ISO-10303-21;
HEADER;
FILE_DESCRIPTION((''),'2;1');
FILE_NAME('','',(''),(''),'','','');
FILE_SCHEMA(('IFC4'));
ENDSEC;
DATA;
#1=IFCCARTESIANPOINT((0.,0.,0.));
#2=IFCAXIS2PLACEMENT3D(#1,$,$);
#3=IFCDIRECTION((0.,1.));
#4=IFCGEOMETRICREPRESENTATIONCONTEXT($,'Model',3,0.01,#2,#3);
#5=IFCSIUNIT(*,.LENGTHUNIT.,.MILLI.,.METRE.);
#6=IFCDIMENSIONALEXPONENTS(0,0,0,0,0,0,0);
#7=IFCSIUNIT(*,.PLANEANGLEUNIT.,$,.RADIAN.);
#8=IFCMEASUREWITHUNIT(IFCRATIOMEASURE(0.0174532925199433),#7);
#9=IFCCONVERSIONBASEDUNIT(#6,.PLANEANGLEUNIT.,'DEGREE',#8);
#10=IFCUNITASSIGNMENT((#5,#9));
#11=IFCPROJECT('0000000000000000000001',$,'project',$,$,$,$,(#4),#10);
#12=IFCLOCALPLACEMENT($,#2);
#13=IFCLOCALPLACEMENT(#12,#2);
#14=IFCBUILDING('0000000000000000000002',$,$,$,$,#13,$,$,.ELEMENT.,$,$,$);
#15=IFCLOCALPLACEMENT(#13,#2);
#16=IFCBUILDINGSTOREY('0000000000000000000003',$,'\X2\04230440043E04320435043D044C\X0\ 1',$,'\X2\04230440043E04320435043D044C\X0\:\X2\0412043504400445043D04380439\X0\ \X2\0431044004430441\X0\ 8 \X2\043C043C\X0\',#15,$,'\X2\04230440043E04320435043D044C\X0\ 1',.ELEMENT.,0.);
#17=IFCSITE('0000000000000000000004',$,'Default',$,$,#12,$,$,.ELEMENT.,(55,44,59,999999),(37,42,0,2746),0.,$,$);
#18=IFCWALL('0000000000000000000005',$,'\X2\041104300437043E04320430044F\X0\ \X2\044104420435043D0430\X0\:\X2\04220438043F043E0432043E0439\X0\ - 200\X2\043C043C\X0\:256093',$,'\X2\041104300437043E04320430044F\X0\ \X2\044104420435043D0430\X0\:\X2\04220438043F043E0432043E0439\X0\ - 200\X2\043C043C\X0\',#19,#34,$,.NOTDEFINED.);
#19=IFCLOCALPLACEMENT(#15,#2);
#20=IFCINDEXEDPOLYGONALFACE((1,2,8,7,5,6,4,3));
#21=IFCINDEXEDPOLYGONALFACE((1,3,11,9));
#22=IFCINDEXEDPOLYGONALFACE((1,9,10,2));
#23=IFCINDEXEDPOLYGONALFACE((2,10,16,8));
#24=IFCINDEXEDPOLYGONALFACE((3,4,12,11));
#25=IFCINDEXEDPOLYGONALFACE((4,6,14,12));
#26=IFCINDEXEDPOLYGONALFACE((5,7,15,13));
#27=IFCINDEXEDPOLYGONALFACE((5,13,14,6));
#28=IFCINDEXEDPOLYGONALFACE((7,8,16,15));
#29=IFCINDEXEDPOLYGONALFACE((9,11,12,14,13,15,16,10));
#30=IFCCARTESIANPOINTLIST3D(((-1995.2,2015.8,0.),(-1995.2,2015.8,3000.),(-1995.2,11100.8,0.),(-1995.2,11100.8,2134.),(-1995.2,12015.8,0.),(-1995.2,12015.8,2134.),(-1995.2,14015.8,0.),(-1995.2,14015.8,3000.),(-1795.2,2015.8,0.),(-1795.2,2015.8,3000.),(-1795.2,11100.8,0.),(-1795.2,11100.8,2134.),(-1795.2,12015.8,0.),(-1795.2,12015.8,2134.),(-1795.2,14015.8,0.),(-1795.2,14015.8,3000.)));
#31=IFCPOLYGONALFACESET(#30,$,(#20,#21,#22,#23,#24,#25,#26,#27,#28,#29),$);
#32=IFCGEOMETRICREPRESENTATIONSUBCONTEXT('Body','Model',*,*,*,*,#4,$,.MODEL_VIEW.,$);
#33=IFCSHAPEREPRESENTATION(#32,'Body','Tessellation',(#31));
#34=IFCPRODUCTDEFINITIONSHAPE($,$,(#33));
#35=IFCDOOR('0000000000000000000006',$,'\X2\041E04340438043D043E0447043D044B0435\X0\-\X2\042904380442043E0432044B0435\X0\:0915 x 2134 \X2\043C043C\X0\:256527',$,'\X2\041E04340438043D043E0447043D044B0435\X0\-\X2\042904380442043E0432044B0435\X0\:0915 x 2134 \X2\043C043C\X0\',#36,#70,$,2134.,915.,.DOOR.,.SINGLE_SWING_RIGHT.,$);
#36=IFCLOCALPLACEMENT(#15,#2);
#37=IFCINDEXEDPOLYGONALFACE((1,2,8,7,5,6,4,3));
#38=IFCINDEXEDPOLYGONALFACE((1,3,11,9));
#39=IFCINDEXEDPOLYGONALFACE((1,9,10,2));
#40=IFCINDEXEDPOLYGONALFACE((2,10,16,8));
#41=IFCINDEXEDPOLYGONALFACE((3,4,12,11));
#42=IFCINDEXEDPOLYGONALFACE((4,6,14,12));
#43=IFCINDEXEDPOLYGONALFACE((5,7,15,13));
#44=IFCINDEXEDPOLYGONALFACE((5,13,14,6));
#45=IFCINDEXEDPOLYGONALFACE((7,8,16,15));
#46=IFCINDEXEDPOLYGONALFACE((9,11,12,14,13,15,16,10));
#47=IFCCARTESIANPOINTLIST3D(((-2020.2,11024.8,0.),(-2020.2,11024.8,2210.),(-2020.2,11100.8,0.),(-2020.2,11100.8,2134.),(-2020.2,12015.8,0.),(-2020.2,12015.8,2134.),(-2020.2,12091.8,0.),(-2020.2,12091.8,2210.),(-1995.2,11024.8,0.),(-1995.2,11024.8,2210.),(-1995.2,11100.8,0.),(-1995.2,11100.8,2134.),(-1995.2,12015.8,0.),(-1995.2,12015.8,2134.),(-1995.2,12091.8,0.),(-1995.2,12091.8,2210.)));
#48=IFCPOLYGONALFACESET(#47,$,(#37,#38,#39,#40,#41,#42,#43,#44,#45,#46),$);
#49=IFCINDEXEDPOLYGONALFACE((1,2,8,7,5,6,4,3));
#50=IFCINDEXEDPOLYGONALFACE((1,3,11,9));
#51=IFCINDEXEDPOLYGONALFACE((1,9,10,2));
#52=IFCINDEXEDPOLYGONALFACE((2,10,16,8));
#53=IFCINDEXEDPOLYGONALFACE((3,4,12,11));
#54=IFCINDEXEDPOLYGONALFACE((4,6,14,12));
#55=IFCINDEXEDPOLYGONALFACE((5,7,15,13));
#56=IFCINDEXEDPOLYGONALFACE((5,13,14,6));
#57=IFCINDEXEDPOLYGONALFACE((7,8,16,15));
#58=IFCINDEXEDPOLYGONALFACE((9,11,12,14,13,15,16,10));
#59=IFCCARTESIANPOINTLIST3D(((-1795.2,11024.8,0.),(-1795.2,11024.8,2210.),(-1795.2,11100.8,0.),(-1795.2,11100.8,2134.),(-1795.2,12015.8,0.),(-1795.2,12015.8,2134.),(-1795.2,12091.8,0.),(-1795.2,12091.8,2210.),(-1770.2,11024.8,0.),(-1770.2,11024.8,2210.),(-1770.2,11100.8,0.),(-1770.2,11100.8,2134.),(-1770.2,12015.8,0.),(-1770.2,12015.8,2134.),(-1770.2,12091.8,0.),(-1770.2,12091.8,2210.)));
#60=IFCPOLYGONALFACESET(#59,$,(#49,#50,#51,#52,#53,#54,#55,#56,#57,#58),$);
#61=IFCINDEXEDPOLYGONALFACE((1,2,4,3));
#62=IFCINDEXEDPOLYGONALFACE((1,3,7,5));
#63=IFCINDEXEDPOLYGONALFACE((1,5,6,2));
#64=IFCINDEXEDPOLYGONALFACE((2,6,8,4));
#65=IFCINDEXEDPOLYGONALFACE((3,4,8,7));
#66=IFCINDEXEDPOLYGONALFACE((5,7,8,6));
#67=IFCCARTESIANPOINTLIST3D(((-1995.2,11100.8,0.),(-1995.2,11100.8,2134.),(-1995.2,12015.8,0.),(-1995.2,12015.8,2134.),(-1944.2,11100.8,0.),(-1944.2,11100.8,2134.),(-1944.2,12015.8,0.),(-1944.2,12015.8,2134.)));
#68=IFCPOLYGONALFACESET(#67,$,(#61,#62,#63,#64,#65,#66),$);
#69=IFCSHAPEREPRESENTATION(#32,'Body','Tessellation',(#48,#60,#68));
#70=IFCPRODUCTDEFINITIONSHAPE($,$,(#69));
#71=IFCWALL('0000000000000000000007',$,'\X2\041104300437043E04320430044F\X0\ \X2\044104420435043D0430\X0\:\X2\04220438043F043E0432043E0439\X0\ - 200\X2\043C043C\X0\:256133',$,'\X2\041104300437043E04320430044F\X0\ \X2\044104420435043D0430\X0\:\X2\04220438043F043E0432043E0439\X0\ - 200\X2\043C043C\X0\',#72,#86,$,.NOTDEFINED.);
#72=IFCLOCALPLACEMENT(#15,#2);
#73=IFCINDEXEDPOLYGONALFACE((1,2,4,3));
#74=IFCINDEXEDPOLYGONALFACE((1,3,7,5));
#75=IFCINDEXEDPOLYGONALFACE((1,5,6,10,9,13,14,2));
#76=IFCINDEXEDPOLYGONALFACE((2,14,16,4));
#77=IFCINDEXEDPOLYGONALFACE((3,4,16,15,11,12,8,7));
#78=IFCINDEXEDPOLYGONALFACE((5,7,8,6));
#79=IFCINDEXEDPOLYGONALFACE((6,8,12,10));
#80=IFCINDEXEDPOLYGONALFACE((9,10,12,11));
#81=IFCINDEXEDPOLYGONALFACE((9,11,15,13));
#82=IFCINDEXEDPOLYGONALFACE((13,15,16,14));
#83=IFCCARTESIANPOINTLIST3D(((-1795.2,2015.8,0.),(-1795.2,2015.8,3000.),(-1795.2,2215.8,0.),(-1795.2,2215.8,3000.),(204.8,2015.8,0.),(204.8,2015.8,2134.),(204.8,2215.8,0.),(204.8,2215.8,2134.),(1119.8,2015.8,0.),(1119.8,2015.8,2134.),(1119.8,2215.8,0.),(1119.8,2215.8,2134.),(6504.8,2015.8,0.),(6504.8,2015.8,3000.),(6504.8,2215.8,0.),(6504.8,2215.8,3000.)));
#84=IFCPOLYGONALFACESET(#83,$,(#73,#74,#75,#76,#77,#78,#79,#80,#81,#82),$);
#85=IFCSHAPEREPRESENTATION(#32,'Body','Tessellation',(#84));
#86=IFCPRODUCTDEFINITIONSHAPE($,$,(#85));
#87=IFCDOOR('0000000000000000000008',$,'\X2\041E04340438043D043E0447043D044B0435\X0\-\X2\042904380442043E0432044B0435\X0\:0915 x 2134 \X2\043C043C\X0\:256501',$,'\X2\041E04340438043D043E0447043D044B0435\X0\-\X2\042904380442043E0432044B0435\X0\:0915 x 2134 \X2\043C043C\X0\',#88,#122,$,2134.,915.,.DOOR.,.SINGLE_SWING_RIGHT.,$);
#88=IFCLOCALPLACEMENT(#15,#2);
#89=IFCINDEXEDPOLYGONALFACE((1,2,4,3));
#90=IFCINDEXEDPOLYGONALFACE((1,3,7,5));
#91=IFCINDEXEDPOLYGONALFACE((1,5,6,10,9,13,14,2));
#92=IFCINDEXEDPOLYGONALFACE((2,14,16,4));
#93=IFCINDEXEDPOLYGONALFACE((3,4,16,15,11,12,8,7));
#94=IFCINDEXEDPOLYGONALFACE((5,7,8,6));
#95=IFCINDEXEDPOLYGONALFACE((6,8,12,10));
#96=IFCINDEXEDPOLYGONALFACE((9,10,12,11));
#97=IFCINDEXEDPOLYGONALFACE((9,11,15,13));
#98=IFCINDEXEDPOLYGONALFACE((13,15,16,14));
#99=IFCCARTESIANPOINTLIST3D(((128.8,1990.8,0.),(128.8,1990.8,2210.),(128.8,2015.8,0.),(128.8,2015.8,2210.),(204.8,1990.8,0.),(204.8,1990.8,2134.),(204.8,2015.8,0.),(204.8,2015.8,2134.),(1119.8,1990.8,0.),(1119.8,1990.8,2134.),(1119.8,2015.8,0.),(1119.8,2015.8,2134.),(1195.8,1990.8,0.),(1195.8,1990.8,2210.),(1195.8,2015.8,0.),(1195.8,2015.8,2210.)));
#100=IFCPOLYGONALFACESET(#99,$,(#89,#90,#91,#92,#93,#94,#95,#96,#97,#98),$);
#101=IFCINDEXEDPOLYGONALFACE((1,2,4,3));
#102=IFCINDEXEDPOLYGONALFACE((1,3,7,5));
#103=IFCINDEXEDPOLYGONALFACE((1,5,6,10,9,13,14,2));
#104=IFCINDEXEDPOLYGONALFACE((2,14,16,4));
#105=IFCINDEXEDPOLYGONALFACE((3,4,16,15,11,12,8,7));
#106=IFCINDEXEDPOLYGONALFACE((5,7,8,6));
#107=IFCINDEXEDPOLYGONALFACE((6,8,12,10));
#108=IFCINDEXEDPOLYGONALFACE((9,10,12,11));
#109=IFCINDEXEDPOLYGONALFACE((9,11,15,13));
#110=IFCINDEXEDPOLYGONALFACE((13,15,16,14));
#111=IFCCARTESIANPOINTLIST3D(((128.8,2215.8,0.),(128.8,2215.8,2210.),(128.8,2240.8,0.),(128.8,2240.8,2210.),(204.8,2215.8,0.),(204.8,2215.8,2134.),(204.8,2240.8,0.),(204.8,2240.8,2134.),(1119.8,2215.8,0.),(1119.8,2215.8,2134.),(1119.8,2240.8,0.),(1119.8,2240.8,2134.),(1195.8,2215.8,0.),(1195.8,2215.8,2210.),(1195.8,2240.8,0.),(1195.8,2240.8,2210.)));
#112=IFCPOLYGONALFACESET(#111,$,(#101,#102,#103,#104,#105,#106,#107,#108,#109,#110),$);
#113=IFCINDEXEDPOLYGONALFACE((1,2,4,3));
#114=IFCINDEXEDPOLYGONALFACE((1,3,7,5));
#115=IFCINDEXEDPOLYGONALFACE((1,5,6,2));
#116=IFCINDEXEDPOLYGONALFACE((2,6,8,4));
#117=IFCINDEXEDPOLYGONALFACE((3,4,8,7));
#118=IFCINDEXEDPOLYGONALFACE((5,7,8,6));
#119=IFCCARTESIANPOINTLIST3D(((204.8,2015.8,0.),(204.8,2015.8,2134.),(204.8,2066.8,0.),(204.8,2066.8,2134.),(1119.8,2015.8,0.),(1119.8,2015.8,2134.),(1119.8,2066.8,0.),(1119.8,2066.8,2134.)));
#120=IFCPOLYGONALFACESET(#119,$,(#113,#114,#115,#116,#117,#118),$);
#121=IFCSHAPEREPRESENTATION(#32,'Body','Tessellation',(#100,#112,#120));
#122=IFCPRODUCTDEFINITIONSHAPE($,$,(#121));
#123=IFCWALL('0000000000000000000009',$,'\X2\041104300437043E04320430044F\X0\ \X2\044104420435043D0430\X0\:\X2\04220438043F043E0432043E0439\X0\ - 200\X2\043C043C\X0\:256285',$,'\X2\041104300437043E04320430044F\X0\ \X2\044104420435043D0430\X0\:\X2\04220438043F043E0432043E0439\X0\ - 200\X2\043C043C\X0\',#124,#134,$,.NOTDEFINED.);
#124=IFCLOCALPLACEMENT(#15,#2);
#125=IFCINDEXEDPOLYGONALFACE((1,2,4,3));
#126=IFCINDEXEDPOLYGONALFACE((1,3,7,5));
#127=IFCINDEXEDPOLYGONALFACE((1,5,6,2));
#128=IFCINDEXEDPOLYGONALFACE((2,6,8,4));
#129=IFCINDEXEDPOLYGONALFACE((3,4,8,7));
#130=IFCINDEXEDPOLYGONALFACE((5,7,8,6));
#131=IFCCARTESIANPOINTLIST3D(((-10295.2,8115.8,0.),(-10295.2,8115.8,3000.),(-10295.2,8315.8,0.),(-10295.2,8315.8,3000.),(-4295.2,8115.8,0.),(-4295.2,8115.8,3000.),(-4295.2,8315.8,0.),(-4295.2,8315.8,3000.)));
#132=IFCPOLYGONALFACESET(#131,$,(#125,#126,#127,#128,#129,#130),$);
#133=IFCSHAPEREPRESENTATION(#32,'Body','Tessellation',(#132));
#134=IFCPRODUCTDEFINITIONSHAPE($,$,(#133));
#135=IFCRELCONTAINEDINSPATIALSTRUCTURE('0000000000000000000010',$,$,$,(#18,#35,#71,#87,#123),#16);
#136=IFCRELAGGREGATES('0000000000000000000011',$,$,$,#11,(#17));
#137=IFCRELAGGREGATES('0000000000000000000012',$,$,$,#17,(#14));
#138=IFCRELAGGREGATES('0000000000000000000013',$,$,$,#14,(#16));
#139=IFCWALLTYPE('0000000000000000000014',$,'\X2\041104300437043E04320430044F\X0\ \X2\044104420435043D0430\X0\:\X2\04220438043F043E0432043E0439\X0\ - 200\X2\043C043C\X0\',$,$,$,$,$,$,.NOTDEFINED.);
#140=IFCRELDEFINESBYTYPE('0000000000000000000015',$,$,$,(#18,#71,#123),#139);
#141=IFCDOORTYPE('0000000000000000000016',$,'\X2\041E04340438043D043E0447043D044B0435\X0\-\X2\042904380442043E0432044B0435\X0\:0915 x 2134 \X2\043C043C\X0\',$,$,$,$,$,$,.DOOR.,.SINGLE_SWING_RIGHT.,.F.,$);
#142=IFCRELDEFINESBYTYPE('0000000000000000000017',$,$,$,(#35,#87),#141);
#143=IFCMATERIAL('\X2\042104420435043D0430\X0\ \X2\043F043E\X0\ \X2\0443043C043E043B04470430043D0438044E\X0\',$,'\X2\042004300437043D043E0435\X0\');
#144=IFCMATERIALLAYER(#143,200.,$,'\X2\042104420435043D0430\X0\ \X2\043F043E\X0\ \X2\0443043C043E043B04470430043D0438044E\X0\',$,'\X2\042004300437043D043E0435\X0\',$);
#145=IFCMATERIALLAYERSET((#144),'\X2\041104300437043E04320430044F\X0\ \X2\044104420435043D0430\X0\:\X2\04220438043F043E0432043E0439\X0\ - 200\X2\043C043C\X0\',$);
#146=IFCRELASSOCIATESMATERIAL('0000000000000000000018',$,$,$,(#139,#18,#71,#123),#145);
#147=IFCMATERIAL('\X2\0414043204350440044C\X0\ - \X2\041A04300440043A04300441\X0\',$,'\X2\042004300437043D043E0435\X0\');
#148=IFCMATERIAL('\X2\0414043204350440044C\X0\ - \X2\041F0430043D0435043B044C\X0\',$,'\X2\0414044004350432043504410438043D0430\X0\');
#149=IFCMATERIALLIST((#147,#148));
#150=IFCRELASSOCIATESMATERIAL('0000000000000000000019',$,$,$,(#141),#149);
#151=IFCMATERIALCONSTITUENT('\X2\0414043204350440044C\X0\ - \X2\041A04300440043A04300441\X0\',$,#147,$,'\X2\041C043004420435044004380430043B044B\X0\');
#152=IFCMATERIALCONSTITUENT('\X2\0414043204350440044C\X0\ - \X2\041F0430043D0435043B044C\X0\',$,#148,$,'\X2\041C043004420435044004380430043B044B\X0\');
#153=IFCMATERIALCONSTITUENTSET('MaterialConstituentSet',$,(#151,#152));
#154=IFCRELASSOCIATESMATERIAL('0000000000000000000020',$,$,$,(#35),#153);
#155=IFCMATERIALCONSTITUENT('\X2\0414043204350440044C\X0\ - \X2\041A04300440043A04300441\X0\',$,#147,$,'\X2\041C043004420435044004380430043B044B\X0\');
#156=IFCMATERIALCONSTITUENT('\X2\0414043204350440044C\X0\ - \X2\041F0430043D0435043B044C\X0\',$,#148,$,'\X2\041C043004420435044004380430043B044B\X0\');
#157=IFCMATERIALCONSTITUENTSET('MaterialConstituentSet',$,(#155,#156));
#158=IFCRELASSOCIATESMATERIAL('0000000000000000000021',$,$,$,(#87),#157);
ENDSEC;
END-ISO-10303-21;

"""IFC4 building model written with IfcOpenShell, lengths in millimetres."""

from ifc_helpers import new_model, entity, si_unit, converted_unit, direction, frame, frame_2d, origin, place, context, subcontext, project, spatial, polyline, rectangle, outline, extrude, source, transform, mapped, material, material_list, layer, layer_set, layer_usage, constituent, constituent_set, type_object, type_shapes, element, fill, save


model = new_model("IFC4")

# Units and contexts
model_context = context("Model", 3, precision=0.01, world=origin(), true_north=direction((0.0, 1.0)))
body_context = subcontext(model_context, "Body", "Model", "MODEL_VIEW")
ifc_project = project(units=[si_unit("LENGTHUNIT", "METRE", prefix="MILLI"), converted_unit("PLANEANGLEUNIT", "DEGREE", entity("IfcRatioMeasure", 0.0174532925199433), si_unit("PLANEANGLEUNIT", "RADIAN"), dimensions=[0, 0, 0, 0, 0, 0, 0])], contexts=[model_context])

# Site, building, storey
site_placement = place(None, origin())
site = spatial("IfcSite", under=ifc_project, at=site_placement, Name="Default", CompositionType="ELEMENT", RefLatitude=(55, 44, 59, 999999), RefLongitude=(37, 42, 0, 2746), RefElevation=0.0)
building_placement = place(site_placement, origin())
building = spatial("IfcBuilding", under=site, at=building_placement, CompositionType="ELEMENT")
storey_placement = place(building_placement, origin())
storey = spatial("IfcBuildingStorey", under=building, at=storey_placement, Name="Уровень 1", ObjectType="Уровень:Верхний брус 8 мм", LongName="Уровень 1", CompositionType="ELEMENT", Elevation=0.0)

# Shared definitions
ifc_material_1 = material(Name="Стена по умолчанию", Category="Разное")
ifc_layer_1 = layer(ifc_material_1, 200.0, Name="Стена по умолчанию", Category="Разное")
ifc_layer_set_1 = layer_set([ifc_layer_1], Name="Базовая стена:Типовой - 200мм")
wall_type = type_object("IfcWallType", Name="Базовая стена:Типовой - 200мм", PredefinedType="NOTDEFINED", material=ifc_layer_set_1)

# Walls, openings, doors
ifc_layer_usage_1 = layer_usage(ifc_layer_set_1, "AXIS2", "NEGATIVE", 100.0)
wall_1_placement = place(storey_placement, frame((-1895.2, 14015.8, 0.0), z_axis=(0.0, 0.0, 1.0), x_axis=(0.0, -1.0, 0.0)))
wall_1 = element("IfcWall", 1, at=wall_1_placement, inside=storey, type_object=wall_type, material=ifc_layer_usage_1, Name="Базовая стена:Типовой - 200мм:256093", ObjectType="Базовая стена:Типовой - 200мм", PredefinedType="NOTDEFINED", context=body_context, shape_type="SweptSolid", body=[
    extrude(rectangle(XDim=12000.0, YDim=200.0, at=frame_2d((6000.0, 0.0), x_axis=(-1.0, 0.0))), origin(), (0.0, 0.0, 1.0), 3000.0),
])
opening_1_placement = place(wall_1_placement, frame((2915.0, 100.0, 0.0)))
opening_1 = element("IfcOpeningElement", 2, at=opening_1_placement, cuts=wall_1, ObjectType="Opening", PredefinedType="OPENING", context=body_context, shape_type="SweptSolid", body=[
    extrude(rectangle(XDim=915.0, YDim=2134.0, at=frame_2d((1067.0, 457.5), x_axis=(0.0, 1.0))), frame((0.0, 0.0, 0.0), z_axis=(0.0, -1.0, 0.0), x_axis=(0.0, 0.0, 1.0)), (0.0, 0.0, 1.0), 200.0),
])
ifc_material_2 = material(Name="Дверь - Каркас", Category="Разное")
ifc_constituent_1 = constituent(ifc_material_2, Name="Дверь - Каркас", Category="Материалы")
ifc_material_3 = material(Name="Дверь - Панель", Category="Древесина")
ifc_constituent_2 = constituent(ifc_material_3, Name="Дверь - Панель", Category="Материалы")
ifc_constituent_set_1 = constituent_set(constituents=[ifc_constituent_1, ifc_constituent_2], Name="MaterialConstituentSet")
ifc_material_list_1 = material_list([ifc_material_2, ifc_material_3])
door_type = type_object("IfcDoorType", Name="Одиночные-Щитовые:0915 x 2134 мм", OperationType="SINGLE_SWING_RIGHT", ParameterTakesPrecedence=False, PredefinedType="DOOR", material=ifc_material_list_1)
shared_shape_1 = source(origin(), body_context, "Body", "SweptSolid", [
    extrude(outline(polyline([(-533.5, -1124.0), (533.5, -1124.0), (533.5, 1086.0), (457.5, 1086.0), (457.5, -1048.0), (-457.5, -1048.0), (-457.5, 1086.0), (-533.5, 1086.0), (-533.5, -1124.0)])), frame((457.5, 200.0, 1086.0), z_axis=(0.0, 1.0, 0.0), x_axis=(1.0, 0.0, 0.0)), (0.0, 0.0, 1.0), 25.0),
    extrude(outline(polyline([(-1124.0, -533.5), (1086.0, -533.5), (1086.0, -457.5), (-1048.0, -457.5), (-1048.0, 457.5), (1086.0, 457.5), (1086.0, 533.5), (-1124.0, 533.5), (-1124.0, -533.5)])), frame((457.5, -25.0, 1086.0), z_axis=(0.0, 1.0, 0.0), x_axis=(0.0, 0.0, -1.0)), (0.0, 0.0, 1.0), 25.0),
    extrude(rectangle(XDim=51.0, YDim=915.0, at=frame_2d((0.0, 0.0), x_axis=(1.0, 0.0))), frame((457.5, 174.5, 0.0), z_axis=(0.0, 0.0, 1.0), x_axis=(0.0, 1.0, 0.0)), (0.0, 0.0, 1.0), 2134.0),
])
type_shapes(door_type, [shared_shape_1])
door_1_placement = place(opening_1_placement, frame((0.0, 0.0, 0.0), z_axis=(0.0, 0.0, 1.0), x_axis=(-1.0, 0.0, 0.0)))
door_1 = element("IfcDoor", 3, at=door_1_placement, inside=storey, type_object=door_type, material=ifc_constituent_set_1, Name="Одиночные-Щитовые:0915 x 2134 мм:256527", ObjectType="Одиночные-Щитовые:0915 x 2134 мм", OperationType="SINGLE_SWING_RIGHT", OverallHeight=2134.0, OverallWidth=915.0, PredefinedType="DOOR", context=body_context, shape_type="MappedRepresentation", body=[
    mapped(shared_shape_1, transform((0.0, 0.0, 0.0), scale=1.0)),
])
fill(opening_1, door_1)
ifc_layer_usage_2 = layer_usage(ifc_layer_set_1, "AXIS2", "NEGATIVE", 100.0)
wall_2_placement = place(storey_placement, frame((-1795.2, 2115.8, 0.0)))
wall_2 = element("IfcWall", 4, at=wall_2_placement, inside=storey, type_object=wall_type, material=ifc_layer_usage_2, Name="Базовая стена:Типовой - 200мм:256133", ObjectType="Базовая стена:Типовой - 200мм", PredefinedType="NOTDEFINED", context=body_context, shape_type="SweptSolid", body=[
    extrude(rectangle(XDim=8300.0, YDim=200.0, at=frame_2d((4150.0, 0.0), x_axis=(-1.0, 0.0))), origin(), (0.0, 0.0, 1.0), 3000.0),
])
opening_2_placement = place(wall_2_placement, frame((2915.0, 100.0, 0.0)))
opening_2 = element("IfcOpeningElement", 5, at=opening_2_placement, cuts=wall_2, ObjectType="Opening", PredefinedType="OPENING", context=body_context, shape_type="SweptSolid", body=[
    extrude(rectangle(XDim=915.0, YDim=2134.0, at=frame_2d((1067.0, 457.5), x_axis=(0.0, 1.0))), frame((0.0, 0.0, 0.0), z_axis=(0.0, -1.0, 0.0), x_axis=(0.0, 0.0, 1.0)), (0.0, 0.0, 1.0), 200.0),
])
ifc_constituent_3 = constituent(ifc_material_2, Name="Дверь - Каркас", Category="Материалы")
ifc_constituent_4 = constituent(ifc_material_3, Name="Дверь - Панель", Category="Материалы")
ifc_constituent_set_2 = constituent_set(constituents=[ifc_constituent_3, ifc_constituent_4], Name="MaterialConstituentSet")
door_2_placement = place(opening_2_placement, frame((0.0, 0.0, 0.0), z_axis=(0.0, 0.0, 1.0), x_axis=(-1.0, 0.0, 0.0)))
door_2 = element("IfcDoor", 6, at=door_2_placement, inside=storey, type_object=door_type, material=ifc_constituent_set_2, Name="Одиночные-Щитовые:0915 x 2134 мм:256501", ObjectType="Одиночные-Щитовые:0915 x 2134 мм", OperationType="SINGLE_SWING_RIGHT", OverallHeight=2134.0, OverallWidth=915.0, PredefinedType="DOOR", context=body_context, shape_type="MappedRepresentation", body=[
    mapped(shared_shape_1, transform((0.0, 0.0, 0.0), scale=1.0)),
])
fill(opening_2, door_2)

# Wall
ifc_layer_usage_3 = layer_usage(ifc_layer_set_1, "AXIS2", "NEGATIVE", 100.0)
wall_3_placement = place(storey_placement, frame((-10295.2, 8215.8, 0.0)))
element("IfcWall", 7, at=wall_3_placement, inside=storey, type_object=wall_type, material=ifc_layer_usage_3, Name="Базовая стена:Типовой - 200мм:256285", ObjectType="Базовая стена:Типовой - 200мм", PredefinedType="NOTDEFINED", context=body_context, shape_type="SweptSolid", body=[
    extrude(rectangle(XDim=6000.0, YDim=200.0, at=frame_2d((3000.0, 0.0), x_axis=(-1.0, 0.0))), origin(), (0.0, 0.0, 1.0), 3000.0),
])

save(model, "model.ifc")
